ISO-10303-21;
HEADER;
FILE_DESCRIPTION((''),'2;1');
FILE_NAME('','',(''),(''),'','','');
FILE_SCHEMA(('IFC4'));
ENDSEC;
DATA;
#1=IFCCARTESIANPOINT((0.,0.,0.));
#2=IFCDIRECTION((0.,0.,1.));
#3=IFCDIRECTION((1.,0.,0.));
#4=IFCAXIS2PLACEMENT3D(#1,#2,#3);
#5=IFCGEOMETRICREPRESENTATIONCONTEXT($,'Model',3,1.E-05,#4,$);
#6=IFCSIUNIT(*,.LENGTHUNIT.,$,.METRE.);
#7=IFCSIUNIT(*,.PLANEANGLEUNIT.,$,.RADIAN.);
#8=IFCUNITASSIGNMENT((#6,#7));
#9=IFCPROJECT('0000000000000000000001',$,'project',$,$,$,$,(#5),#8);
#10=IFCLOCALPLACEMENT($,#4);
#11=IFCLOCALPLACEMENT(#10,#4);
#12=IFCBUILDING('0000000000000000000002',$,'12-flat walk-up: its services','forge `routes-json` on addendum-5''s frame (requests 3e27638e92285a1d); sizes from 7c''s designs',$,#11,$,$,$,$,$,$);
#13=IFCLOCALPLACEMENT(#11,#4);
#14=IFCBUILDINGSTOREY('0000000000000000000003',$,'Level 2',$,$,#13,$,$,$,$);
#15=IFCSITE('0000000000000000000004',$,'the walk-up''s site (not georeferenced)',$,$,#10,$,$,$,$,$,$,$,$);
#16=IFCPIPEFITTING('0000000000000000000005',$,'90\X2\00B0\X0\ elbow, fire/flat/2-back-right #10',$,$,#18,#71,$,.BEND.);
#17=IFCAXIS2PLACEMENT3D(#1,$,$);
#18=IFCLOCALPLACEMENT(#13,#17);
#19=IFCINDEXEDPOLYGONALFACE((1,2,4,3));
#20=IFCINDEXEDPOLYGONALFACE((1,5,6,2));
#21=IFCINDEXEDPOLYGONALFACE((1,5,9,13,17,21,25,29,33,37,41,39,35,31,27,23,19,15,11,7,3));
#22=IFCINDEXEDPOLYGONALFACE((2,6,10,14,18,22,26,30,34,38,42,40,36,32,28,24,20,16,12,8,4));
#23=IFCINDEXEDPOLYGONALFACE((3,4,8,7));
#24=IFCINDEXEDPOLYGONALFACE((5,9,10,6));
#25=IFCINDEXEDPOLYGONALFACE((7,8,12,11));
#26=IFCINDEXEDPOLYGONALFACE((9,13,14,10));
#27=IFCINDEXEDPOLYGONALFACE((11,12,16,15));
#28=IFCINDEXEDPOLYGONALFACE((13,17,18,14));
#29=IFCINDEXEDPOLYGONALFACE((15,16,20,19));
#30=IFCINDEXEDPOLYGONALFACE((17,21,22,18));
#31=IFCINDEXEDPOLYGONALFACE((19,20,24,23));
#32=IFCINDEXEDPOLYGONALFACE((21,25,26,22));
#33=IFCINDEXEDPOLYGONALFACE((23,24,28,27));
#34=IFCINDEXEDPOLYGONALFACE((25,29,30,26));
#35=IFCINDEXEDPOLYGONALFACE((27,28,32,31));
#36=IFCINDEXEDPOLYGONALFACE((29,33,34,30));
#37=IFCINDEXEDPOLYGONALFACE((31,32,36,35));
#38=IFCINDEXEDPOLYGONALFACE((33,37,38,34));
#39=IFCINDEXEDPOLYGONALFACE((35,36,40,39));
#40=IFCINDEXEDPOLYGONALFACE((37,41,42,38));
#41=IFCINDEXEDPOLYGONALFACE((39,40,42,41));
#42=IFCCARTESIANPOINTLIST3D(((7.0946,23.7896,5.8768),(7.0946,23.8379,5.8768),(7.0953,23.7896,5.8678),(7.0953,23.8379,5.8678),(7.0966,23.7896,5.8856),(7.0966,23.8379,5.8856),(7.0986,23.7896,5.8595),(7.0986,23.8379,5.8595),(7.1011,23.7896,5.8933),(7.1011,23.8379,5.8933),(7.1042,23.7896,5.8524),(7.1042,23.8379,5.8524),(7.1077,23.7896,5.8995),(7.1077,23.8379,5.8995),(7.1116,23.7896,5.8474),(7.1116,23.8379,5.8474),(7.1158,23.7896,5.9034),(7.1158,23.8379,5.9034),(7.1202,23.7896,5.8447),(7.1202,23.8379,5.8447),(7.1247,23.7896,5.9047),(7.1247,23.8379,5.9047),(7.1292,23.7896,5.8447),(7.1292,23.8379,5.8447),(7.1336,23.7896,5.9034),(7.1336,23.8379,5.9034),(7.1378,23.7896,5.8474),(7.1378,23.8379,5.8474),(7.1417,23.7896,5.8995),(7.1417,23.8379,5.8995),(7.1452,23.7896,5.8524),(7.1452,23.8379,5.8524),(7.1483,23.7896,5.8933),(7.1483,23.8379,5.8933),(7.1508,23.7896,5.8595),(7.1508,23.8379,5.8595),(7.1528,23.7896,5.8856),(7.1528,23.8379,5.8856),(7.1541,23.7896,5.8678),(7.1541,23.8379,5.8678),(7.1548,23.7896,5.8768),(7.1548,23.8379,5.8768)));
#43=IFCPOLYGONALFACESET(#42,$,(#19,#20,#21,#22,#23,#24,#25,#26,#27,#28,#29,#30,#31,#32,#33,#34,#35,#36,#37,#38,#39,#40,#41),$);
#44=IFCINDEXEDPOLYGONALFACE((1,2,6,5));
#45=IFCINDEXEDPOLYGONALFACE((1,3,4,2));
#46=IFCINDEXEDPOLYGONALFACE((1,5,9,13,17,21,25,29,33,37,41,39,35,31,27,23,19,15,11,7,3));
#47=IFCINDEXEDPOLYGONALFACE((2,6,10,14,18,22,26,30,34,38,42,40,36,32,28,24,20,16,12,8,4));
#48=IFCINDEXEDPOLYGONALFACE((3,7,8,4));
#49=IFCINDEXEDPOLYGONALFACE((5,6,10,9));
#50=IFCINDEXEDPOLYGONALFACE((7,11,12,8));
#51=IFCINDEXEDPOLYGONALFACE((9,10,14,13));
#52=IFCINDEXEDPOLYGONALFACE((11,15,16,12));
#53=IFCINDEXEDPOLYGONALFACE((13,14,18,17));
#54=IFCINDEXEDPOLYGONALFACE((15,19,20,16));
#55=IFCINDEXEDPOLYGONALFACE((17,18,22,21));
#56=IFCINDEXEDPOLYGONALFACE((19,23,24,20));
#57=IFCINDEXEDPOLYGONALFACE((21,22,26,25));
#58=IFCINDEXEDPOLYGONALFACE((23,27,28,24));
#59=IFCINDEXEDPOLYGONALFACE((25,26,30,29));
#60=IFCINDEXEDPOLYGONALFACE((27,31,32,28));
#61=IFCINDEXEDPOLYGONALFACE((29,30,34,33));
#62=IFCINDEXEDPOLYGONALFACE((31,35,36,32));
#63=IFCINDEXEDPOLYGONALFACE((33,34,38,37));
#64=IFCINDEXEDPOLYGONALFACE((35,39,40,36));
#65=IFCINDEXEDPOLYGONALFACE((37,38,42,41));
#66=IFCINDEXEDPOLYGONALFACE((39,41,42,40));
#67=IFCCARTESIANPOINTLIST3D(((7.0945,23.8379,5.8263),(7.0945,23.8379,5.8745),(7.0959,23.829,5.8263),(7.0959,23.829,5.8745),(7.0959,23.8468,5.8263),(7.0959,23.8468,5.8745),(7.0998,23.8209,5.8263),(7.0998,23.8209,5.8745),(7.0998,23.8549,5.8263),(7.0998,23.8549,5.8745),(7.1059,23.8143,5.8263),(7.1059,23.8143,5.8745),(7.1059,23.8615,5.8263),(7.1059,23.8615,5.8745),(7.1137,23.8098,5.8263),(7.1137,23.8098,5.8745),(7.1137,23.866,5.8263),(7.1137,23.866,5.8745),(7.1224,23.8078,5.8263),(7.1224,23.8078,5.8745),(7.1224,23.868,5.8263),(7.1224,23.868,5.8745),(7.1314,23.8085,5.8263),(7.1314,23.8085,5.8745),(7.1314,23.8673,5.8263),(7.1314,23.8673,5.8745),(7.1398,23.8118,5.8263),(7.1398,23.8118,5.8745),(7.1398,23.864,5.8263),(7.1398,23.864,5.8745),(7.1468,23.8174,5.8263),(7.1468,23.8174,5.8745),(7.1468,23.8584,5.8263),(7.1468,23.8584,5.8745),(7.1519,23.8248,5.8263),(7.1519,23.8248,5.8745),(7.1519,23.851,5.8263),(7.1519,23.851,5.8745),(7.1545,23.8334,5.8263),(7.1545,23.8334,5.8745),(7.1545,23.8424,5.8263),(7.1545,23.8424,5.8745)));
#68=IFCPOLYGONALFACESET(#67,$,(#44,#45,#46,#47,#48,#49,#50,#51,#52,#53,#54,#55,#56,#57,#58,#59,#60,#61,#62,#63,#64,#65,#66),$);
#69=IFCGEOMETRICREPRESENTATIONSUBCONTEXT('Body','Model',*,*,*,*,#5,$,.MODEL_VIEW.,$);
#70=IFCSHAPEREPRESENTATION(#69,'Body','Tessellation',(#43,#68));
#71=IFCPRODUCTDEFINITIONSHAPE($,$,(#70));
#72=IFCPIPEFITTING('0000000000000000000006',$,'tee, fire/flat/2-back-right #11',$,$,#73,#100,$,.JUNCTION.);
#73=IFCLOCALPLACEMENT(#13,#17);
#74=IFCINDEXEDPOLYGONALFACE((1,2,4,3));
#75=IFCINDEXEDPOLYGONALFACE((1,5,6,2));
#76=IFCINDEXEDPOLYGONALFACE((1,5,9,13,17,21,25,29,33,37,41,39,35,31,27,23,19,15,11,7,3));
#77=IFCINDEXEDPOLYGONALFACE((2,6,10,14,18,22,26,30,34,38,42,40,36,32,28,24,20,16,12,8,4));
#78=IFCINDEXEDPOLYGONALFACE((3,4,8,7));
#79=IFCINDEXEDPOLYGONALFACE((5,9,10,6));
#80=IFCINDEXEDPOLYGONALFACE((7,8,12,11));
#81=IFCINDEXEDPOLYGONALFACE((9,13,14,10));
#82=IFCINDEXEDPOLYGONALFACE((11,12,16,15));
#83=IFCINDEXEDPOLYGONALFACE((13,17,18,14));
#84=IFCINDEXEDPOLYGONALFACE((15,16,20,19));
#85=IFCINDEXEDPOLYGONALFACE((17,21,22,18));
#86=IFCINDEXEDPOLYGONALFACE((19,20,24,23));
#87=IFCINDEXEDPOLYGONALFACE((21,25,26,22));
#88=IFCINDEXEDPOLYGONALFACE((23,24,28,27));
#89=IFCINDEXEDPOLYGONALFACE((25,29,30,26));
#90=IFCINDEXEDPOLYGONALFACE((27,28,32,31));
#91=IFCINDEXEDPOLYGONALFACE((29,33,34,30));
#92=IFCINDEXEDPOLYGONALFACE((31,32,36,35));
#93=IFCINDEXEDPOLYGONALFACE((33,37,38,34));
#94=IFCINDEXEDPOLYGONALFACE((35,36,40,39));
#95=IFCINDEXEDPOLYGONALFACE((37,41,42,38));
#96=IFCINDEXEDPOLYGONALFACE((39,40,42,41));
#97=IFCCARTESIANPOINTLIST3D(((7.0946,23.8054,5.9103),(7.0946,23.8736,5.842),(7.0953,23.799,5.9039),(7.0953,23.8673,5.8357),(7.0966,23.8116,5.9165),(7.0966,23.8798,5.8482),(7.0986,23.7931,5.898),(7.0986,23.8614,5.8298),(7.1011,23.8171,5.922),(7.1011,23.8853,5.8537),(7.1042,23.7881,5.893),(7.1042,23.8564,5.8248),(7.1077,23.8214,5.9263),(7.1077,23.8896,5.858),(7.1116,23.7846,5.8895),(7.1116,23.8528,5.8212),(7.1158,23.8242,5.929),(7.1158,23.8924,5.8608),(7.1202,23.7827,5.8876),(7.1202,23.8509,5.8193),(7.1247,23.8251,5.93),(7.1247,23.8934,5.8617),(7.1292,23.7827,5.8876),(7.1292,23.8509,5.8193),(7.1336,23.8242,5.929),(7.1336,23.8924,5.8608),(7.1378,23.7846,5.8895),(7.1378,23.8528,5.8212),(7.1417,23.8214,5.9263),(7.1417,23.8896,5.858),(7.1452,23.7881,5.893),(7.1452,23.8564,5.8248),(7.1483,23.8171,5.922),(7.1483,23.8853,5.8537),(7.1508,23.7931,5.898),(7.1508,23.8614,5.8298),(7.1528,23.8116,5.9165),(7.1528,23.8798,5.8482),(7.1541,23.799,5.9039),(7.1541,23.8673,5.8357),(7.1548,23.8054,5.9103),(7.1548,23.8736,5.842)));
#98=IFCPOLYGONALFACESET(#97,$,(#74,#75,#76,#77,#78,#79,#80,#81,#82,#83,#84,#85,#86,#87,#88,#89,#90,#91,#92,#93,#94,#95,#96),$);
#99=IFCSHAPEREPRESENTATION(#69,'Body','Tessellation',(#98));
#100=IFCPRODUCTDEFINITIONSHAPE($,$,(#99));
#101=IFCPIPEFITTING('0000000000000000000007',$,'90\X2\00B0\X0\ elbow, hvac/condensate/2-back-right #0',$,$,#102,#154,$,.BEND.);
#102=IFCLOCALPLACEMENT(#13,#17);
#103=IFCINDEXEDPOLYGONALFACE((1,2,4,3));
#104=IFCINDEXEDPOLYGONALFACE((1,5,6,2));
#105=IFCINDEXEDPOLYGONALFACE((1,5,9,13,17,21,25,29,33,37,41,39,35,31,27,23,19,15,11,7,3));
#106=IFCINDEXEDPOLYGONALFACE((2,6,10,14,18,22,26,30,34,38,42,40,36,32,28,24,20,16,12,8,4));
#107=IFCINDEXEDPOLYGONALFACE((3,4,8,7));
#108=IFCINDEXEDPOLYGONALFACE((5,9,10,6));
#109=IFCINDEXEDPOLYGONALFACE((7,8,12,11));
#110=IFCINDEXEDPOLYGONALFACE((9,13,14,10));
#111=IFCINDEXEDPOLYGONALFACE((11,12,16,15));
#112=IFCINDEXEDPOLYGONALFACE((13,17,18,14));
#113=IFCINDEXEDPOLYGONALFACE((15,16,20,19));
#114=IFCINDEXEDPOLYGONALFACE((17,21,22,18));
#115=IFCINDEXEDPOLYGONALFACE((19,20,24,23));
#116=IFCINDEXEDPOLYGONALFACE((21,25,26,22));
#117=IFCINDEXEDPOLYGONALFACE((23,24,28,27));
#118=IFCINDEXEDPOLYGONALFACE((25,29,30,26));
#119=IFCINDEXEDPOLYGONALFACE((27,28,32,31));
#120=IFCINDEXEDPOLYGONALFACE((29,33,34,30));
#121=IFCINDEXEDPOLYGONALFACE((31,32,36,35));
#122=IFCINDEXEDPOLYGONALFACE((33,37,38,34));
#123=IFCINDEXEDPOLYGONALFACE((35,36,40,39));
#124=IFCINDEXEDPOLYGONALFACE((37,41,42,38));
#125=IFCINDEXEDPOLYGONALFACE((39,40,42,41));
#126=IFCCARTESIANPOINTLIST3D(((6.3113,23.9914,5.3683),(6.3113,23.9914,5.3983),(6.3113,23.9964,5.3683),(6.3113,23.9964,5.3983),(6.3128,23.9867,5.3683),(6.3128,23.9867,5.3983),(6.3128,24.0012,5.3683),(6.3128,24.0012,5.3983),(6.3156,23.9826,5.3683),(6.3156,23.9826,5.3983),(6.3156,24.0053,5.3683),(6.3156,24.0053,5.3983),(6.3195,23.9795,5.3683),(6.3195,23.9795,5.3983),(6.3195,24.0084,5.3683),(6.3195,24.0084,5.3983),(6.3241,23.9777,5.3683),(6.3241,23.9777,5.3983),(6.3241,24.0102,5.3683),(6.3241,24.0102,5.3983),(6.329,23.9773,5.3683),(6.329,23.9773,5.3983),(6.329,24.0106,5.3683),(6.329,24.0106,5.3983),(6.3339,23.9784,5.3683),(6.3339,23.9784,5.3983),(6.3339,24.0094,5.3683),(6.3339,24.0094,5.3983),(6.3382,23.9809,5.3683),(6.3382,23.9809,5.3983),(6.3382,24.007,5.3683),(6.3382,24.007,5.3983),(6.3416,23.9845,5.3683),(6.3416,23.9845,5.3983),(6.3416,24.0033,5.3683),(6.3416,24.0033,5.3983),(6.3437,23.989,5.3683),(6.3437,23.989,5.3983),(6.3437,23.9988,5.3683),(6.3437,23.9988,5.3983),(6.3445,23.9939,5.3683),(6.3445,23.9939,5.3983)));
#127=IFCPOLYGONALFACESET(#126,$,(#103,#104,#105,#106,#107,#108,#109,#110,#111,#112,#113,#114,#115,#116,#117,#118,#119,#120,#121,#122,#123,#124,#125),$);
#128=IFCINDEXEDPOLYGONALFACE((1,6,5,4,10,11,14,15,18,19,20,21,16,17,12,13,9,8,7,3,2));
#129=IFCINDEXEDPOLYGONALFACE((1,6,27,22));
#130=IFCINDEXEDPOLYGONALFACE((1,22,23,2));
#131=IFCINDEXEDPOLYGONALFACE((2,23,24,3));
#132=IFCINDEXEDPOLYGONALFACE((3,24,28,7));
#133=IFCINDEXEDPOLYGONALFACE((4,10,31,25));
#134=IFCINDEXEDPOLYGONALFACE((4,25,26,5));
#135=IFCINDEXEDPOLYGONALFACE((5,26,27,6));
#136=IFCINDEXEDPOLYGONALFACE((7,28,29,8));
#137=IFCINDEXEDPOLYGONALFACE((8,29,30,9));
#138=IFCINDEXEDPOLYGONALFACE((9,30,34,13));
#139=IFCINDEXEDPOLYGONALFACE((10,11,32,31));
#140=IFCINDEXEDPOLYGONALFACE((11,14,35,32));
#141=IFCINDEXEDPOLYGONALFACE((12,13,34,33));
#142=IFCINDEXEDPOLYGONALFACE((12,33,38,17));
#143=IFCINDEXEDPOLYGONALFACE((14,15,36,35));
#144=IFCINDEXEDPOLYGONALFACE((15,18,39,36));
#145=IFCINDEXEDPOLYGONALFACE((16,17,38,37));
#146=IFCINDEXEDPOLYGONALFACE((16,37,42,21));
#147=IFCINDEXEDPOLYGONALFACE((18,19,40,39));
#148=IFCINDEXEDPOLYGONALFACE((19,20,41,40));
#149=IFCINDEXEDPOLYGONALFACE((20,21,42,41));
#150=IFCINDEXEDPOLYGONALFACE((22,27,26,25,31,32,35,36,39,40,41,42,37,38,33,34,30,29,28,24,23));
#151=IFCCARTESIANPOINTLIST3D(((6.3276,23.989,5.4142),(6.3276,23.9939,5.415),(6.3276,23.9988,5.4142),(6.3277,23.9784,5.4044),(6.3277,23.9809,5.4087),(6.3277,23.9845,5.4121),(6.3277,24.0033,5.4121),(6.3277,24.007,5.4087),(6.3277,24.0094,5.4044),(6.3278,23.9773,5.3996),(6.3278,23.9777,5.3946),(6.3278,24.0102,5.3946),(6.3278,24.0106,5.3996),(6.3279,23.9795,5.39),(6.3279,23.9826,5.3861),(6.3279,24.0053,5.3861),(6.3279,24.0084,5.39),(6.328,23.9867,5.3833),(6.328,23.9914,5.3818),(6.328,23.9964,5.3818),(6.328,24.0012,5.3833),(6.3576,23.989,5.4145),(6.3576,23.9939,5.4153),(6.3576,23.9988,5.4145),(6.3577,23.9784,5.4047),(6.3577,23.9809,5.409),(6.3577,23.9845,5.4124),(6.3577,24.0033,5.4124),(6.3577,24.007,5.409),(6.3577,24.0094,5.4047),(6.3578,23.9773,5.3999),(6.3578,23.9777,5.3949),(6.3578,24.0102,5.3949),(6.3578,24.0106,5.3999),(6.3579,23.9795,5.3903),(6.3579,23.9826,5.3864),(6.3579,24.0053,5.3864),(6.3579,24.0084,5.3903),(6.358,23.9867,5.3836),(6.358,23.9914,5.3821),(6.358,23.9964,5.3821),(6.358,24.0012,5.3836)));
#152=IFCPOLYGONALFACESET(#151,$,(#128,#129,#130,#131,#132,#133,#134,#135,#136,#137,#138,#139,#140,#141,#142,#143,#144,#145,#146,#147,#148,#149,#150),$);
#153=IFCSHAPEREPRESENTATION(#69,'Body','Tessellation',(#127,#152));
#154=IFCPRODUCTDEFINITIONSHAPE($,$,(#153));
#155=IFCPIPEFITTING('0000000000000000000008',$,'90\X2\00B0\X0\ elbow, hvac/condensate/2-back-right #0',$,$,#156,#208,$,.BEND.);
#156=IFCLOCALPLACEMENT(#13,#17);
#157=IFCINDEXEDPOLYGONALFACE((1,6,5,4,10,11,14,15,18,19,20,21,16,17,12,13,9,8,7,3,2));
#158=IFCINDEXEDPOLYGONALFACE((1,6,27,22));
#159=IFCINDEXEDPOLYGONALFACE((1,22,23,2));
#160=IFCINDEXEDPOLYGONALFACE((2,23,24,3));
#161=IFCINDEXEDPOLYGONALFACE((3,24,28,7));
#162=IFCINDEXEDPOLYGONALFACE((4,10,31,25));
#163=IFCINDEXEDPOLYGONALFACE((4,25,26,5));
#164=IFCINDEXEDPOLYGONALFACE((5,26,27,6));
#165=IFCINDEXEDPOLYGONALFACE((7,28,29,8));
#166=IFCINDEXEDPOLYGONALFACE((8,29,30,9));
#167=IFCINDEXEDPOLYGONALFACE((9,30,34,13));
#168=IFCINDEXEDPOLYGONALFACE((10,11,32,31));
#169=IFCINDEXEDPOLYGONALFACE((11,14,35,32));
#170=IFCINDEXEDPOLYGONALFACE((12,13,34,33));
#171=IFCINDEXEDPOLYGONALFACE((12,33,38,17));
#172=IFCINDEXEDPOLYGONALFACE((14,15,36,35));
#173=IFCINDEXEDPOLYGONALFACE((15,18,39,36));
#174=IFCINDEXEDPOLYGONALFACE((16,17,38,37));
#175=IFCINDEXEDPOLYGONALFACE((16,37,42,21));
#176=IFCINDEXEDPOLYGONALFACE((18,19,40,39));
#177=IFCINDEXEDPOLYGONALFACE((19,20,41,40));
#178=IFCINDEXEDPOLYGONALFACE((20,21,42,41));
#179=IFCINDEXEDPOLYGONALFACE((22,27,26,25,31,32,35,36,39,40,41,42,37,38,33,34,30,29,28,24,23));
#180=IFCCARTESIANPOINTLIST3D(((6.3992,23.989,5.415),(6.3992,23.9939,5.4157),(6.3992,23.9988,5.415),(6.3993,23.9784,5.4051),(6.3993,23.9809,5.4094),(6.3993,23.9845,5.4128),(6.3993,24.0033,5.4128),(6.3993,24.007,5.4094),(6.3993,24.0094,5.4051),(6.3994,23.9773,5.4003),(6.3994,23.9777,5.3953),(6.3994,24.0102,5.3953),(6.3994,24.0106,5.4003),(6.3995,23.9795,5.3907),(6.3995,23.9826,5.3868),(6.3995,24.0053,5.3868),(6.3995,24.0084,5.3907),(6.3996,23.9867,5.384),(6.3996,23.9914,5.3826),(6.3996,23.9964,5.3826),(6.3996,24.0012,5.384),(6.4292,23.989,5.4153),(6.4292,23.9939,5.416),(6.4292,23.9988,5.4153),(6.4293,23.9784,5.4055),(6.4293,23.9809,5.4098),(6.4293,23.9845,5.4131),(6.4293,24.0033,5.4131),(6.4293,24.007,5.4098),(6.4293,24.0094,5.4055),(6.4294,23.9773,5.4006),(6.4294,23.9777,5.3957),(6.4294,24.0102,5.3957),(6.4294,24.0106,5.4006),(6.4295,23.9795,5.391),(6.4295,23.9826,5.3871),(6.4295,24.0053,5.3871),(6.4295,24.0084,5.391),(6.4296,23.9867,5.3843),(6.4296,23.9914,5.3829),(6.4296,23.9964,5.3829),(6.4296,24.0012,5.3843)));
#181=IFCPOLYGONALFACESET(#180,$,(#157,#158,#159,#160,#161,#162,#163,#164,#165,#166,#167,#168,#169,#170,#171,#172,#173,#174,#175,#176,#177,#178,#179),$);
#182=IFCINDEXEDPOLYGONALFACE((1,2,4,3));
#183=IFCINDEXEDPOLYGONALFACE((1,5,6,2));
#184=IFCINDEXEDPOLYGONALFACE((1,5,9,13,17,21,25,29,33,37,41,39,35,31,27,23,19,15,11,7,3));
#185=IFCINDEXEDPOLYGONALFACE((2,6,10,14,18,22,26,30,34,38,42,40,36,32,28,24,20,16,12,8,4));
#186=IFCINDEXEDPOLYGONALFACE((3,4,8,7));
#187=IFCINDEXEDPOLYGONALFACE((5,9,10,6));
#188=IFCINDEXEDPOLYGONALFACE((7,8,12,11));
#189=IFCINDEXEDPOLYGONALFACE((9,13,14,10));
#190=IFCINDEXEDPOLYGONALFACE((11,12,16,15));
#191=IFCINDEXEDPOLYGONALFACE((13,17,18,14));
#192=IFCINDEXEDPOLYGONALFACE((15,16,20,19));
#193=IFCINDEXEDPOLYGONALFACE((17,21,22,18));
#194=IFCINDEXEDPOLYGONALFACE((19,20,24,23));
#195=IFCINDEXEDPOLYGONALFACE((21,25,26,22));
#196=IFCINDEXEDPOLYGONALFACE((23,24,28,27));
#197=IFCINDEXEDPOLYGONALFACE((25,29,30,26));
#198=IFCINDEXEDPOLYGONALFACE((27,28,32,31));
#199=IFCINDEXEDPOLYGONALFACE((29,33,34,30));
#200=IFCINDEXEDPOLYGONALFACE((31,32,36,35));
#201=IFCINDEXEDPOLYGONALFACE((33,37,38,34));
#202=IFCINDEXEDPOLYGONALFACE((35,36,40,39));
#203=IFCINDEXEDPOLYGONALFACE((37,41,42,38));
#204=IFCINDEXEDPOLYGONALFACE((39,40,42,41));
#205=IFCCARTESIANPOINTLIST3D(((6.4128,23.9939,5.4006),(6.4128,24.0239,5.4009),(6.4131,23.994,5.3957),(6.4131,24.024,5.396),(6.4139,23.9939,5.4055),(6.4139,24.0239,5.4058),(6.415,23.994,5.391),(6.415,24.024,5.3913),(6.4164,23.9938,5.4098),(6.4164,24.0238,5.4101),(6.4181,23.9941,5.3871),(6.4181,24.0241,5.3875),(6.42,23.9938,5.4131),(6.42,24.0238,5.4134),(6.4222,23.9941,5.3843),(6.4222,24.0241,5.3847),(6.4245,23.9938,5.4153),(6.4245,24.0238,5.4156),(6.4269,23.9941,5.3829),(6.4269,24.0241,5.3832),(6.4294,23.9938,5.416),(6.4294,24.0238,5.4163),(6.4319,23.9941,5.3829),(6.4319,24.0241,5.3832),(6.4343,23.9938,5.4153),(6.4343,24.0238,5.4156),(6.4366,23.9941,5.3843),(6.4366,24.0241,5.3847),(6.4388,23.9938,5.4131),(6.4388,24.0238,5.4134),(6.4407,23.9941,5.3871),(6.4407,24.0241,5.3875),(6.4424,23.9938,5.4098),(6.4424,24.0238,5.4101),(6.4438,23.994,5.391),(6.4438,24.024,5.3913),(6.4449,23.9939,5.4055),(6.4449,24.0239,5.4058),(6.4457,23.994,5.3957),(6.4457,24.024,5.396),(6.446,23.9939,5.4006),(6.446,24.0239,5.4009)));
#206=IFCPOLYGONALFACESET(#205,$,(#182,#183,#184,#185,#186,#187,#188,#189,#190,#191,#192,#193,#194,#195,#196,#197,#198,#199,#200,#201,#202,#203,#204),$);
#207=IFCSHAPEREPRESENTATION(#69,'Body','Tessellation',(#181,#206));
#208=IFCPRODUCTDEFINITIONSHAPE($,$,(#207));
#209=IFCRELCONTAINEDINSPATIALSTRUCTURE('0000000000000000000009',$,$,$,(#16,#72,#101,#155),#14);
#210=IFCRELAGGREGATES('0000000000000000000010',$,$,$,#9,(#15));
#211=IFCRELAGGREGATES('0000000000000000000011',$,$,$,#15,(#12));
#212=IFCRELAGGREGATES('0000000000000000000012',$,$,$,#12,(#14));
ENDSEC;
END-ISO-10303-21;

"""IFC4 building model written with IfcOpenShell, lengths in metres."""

from ifc_helpers import new_model, entity, si_unit, frame, origin_with_axes, place, context, subcontext, project, spatial, element, save


model = new_model("IFC4")

# Units and contexts
model_context = context("Model", 3, precision=1e-05, world=origin_with_axes())
body_context = subcontext(model_context, "Body", "Model", "MODEL_VIEW")
ifc_project = project(units=[si_unit("LENGTHUNIT", "METRE"), si_unit("PLANEANGLEUNIT", "RADIAN")], contexts=[model_context])

# Site, building, storey
site_placement = place(None, origin_with_axes())
site = spatial("IfcSite", under=ifc_project, at=site_placement, Name="the walk-up's site (not georeferenced)")
building_placement = place(site_placement, origin_with_axes())
building = spatial("IfcBuilding", under=site, at=building_placement, Name="12-flat walk-up: its services", Description="forge `routes-json` on addendum-5's frame (requests 3e27638e92285a1d); sizes from 7c's designs")
storey_placement = place(building_placement, origin_with_axes())
storey = spatial("IfcBuildingStorey", under=building, at=storey_placement, Name="Level 2")

# Pipe fittings
pipe_fitting_1_placement = place(storey_placement, frame((7.1247, 23.7896, 5.8745), z_axis=(0.0, 0.0, 1.0), x_axis=(1.0, 0.0, 0.0)))
element("IfcPipeFitting", 1, at=pipe_fitting_1_placement, inside=storey, Name="90° elbow, fire/flat/2-back-right #10", PredefinedType="BEND", context=body_context, shape_type="AdvancedSweptSolid", body=[
    entity("IfcSweptDiskSolid", entity("IfcPolyline", [entity("IfcCartesianPoint", [0.0, 0.0, 0.0]), entity("IfcCartesianPoint", [0.0, 0.0483, 0.0])]), 0.0302),
    entity("IfcSweptDiskSolid", entity("IfcPolyline", [entity("IfcCartesianPoint", [0.0, 0.0483, 0.0]), entity("IfcCartesianPoint", [0.0, 0.0483, -0.0483])]), 0.0302),
])
pipe_fitting_2_placement = place(storey_placement, frame((7.1247, 23.8038, 5.9087), z_axis=(0.0, 0.0, 1.0), x_axis=(1.0, 0.0, 0.0)))
element("IfcPipeFitting", 2, at=pipe_fitting_2_placement, inside=storey, Name="tee, fire/flat/2-back-right #11", PredefinedType="JUNCTION", context=body_context, shape_type="AdvancedSweptSolid", body=[
    entity("IfcSweptDiskSolid", entity("IfcPolyline", [entity("IfcCartesianPoint", [0.0, 0.0, 0.0]), entity("IfcCartesianPoint", [0.0, 0.0682, -0.0682])]), 0.0302),
])

# Pipe fittings
pipe_fitting_3_placement = place(storey_placement, frame((6.3278, 23.9939, 5.3683), z_axis=(0.0, 0.0, 1.0), x_axis=(1.0, 0.0, 0.0)))
element("IfcPipeFitting", 3, at=pipe_fitting_3_placement, inside=storey, Name="90° elbow, hvac/condensate/2-back-right #0", PredefinedType="BEND", context=body_context, shape_type="AdvancedSweptSolid", body=[
    entity("IfcSweptDiskSolid", entity("IfcPolyline", [entity("IfcCartesianPoint", [0.0, 0.0, 0.0]), entity("IfcCartesianPoint", [0.0, 0.0, 0.03])]), 0.0167),
    entity("IfcSweptDiskSolid", entity("IfcPolyline", [entity("IfcCartesianPoint", [0.0, 0.0, 0.03]), entity("IfcCartesianPoint", [0.03, 0.0, 0.0303])]), 0.0167),
])
pipe_fitting_4_placement = place(storey_placement, frame((6.3994, 23.9939, 5.3991), z_axis=(0.0, 0.0, 1.0), x_axis=(1.0, 0.0, 0.0)))
element("IfcPipeFitting", 4, at=pipe_fitting_4_placement, inside=storey, Name="90° elbow, hvac/condensate/2-back-right #0", PredefinedType="BEND", context=body_context, shape_type="AdvancedSweptSolid", body=[
    entity("IfcSweptDiskSolid", entity("IfcPolyline", [entity("IfcCartesianPoint", [0.0, 0.0, 0.0]), entity("IfcCartesianPoint", [0.03, 0.0, 0.0003])]), 0.0167),
    entity("IfcSweptDiskSolid", entity("IfcPolyline", [entity("IfcCartesianPoint", [0.03, 0.0, 0.0003]), entity("IfcCartesianPoint", [0.03, 0.03, 0.0006])]), 0.0167),
])

save(model, "model.ifc")
